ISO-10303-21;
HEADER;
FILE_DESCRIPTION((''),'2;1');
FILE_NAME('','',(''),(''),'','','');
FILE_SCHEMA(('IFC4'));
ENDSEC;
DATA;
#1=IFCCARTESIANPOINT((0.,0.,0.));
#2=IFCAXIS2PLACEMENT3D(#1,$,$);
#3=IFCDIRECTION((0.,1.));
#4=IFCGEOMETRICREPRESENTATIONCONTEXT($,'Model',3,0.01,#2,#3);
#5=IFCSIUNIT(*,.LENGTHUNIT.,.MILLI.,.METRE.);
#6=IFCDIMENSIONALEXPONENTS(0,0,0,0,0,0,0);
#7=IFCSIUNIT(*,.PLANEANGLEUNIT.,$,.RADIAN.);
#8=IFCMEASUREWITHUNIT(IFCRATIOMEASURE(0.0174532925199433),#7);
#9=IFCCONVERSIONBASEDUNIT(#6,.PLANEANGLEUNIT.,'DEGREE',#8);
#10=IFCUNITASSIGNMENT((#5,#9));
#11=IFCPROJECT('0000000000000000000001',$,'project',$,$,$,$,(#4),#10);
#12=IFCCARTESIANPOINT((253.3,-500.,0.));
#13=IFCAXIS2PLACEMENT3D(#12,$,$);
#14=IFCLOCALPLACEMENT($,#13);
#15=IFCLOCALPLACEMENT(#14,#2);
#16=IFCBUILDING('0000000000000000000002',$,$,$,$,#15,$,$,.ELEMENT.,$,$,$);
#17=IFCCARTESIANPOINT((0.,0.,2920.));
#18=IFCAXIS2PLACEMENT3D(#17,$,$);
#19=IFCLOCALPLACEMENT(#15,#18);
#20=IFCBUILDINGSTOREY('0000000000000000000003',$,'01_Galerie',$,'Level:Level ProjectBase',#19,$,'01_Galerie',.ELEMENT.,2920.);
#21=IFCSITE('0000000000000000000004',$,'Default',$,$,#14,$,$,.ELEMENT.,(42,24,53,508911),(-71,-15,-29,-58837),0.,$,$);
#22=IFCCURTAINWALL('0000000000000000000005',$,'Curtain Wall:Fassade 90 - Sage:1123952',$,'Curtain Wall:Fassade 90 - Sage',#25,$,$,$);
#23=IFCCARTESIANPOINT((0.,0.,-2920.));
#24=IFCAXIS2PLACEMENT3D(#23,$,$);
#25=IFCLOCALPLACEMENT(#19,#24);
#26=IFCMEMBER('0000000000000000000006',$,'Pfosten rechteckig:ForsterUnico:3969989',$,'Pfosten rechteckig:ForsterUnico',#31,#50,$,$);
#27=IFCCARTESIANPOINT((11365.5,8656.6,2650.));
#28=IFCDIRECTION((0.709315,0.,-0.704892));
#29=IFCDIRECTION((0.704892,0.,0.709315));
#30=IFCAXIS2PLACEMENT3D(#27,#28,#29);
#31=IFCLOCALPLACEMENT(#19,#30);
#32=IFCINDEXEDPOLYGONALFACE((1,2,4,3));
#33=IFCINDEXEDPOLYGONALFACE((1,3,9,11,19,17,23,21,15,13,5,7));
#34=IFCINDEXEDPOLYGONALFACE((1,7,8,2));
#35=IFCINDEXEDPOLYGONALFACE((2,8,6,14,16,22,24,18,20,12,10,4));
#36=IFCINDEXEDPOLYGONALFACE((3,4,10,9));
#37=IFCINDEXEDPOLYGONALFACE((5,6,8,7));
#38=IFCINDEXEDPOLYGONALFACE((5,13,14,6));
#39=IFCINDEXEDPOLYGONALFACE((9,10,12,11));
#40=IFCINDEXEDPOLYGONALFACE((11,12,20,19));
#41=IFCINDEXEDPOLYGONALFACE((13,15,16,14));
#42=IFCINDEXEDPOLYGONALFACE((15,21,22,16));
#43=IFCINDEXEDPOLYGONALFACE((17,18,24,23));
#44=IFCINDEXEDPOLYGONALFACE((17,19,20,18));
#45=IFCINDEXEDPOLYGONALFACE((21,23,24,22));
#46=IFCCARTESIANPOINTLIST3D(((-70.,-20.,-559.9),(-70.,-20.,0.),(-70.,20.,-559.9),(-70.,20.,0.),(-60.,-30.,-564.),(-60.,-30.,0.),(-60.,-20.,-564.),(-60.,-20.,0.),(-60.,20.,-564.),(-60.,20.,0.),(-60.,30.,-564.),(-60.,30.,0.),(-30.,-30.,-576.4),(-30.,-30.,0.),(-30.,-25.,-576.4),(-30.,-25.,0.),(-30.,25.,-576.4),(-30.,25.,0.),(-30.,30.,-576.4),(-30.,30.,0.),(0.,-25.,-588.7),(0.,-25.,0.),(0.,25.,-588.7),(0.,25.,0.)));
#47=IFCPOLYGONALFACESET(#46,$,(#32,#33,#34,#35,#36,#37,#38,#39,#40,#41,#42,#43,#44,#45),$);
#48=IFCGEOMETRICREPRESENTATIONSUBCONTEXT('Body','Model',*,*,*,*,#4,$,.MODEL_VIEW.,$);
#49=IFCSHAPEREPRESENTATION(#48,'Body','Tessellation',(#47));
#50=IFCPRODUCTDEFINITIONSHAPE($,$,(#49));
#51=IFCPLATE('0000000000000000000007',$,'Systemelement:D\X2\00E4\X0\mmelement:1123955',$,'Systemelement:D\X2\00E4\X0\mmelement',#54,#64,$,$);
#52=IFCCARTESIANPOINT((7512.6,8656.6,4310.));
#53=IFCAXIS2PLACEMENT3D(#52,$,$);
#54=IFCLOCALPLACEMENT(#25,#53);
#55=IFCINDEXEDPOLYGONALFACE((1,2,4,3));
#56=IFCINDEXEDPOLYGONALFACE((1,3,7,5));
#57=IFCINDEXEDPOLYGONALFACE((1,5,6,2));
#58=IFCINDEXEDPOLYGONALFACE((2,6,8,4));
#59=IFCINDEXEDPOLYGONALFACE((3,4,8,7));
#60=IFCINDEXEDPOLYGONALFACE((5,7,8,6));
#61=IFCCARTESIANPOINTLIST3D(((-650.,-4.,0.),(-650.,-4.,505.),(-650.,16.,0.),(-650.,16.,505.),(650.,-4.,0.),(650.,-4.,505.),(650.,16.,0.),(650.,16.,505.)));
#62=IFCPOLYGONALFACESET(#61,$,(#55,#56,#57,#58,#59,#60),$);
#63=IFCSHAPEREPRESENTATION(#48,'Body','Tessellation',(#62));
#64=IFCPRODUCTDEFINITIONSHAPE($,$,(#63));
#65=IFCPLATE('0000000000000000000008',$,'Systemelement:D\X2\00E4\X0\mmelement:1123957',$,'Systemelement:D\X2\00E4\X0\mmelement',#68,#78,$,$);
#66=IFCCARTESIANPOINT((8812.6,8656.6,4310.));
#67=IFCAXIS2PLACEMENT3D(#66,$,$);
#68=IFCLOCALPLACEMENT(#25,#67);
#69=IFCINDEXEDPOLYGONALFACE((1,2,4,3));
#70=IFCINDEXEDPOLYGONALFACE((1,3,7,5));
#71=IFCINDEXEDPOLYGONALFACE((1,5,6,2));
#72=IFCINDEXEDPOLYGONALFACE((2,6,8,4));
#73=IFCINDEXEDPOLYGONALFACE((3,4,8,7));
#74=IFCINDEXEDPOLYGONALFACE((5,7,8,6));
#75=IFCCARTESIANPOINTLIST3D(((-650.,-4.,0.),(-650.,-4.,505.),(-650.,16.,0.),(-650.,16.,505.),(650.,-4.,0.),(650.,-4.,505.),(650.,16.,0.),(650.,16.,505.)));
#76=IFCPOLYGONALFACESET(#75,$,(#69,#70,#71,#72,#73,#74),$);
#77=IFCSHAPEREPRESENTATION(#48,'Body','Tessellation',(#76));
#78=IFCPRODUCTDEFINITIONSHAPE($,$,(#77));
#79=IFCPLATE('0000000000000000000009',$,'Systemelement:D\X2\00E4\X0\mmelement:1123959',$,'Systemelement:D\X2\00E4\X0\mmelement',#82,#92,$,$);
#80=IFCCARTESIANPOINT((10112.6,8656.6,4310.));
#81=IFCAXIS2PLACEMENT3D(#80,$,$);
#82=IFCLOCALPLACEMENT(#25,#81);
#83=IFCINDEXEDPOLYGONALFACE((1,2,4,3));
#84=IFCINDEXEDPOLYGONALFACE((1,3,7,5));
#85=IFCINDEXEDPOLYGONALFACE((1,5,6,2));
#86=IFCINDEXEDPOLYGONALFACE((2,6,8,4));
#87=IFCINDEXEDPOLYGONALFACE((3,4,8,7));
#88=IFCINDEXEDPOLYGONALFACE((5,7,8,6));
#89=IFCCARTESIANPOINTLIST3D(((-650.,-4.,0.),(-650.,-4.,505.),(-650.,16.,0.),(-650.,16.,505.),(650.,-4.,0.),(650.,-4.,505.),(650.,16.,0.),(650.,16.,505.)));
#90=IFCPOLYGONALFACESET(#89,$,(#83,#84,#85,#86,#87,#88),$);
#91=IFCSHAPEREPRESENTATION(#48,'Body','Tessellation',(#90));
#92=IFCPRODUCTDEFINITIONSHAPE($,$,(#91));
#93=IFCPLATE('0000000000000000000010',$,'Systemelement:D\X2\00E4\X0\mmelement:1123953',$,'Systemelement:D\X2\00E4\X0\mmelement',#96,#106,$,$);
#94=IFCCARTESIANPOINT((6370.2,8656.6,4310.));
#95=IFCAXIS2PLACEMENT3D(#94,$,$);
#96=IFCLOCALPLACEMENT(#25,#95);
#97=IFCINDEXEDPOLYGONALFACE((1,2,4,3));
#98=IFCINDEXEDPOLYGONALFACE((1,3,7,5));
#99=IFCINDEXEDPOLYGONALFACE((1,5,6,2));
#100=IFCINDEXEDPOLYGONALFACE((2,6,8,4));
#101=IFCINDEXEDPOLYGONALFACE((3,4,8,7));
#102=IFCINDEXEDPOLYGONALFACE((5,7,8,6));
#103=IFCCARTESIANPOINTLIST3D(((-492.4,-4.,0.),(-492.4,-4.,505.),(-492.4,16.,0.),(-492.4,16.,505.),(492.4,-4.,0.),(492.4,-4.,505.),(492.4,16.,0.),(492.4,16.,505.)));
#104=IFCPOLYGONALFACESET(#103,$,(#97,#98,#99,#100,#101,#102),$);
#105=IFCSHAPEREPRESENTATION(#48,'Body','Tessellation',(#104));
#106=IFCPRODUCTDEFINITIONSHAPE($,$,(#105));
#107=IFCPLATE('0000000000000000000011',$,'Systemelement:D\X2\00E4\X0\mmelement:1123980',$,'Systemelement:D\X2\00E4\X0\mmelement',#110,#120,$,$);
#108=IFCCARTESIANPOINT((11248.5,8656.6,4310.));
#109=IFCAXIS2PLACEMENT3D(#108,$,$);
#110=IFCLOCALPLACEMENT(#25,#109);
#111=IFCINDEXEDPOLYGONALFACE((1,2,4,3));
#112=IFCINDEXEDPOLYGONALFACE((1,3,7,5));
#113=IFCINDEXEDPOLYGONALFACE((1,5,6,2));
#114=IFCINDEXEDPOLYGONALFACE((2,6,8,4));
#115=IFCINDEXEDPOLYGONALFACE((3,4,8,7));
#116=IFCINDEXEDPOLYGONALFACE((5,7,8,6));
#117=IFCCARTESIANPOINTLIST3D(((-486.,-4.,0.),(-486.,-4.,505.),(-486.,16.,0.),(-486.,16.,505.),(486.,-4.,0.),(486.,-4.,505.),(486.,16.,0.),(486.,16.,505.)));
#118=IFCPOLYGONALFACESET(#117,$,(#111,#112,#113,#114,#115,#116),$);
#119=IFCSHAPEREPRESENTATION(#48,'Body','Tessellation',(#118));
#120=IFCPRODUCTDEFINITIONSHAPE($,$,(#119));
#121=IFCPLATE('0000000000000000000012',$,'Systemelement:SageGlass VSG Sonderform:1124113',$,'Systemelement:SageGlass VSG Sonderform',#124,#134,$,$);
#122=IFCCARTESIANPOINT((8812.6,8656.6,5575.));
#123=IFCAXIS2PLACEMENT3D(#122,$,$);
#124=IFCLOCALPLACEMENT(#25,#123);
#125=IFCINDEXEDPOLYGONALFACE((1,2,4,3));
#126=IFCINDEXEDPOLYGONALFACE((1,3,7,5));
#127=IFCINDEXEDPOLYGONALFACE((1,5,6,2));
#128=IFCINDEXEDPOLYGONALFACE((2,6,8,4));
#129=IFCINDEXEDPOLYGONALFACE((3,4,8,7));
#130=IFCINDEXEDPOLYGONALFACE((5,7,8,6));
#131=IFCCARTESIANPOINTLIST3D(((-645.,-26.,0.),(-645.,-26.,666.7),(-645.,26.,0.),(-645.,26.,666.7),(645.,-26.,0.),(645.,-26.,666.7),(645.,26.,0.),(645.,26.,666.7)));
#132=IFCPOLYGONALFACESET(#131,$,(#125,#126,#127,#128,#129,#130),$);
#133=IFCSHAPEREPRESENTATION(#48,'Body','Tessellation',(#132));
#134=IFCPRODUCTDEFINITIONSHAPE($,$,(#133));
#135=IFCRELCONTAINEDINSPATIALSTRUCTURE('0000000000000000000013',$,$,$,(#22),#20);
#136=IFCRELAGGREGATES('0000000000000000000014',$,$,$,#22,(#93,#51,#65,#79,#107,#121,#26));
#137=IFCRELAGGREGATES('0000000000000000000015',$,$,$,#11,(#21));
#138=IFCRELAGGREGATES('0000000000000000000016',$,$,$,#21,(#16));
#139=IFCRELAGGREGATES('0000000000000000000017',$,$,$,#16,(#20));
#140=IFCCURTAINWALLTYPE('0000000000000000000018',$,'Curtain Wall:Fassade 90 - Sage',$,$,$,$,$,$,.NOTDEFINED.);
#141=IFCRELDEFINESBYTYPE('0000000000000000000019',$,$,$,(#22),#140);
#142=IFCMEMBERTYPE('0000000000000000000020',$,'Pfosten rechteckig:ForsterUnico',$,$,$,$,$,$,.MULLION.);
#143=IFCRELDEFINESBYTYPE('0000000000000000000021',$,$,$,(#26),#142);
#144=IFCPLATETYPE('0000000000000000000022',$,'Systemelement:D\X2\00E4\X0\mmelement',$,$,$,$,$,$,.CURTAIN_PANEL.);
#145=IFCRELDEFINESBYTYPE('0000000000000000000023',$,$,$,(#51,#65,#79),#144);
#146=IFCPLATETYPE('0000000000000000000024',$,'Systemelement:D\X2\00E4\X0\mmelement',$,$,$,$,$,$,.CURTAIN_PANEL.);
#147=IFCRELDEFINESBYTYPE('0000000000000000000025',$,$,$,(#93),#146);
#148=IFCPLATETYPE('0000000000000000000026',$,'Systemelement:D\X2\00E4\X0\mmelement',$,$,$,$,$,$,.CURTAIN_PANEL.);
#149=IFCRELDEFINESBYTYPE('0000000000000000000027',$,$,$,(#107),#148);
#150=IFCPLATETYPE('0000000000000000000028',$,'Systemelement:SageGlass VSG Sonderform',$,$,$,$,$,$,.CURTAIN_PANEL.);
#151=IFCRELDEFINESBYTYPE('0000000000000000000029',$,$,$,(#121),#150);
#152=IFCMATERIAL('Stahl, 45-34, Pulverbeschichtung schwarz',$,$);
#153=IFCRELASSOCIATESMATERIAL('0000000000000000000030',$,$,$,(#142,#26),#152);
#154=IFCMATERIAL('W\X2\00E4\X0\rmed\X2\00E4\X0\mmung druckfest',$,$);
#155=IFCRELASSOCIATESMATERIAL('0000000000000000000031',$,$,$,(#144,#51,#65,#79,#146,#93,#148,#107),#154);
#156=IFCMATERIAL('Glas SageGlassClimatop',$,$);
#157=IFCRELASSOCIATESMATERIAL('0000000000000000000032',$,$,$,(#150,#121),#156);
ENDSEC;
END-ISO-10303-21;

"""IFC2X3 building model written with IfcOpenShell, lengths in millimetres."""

from ifc_helpers import new_model, entity, si_unit, converted_unit, direction, frame, origin, origin_2d_with_axis, place, context, subcontext, project, spatial, polyline, rectangle, outline, extrude, clip, halfspace, source, transform, mapped, material, type_object, type_shapes, element, aggregate, save


model = new_model("IFC2X3")

# Units and contexts
model_context = context("Model", 3, precision=0.01, world=origin(), true_north=direction((0.0, 1.0)))
body_context = subcontext(model_context, "Body", "Model", "MODEL_VIEW")
ifc_project = project(units=[si_unit("LENGTHUNIT", "METRE", prefix="MILLI"), converted_unit("PLANEANGLEUNIT", "DEGREE", entity("IfcRatioMeasure", 0.0174532925199433), si_unit("PLANEANGLEUNIT", "RADIAN"), dimensions=[0, 0, 0, 0, 0, 0, 0])], contexts=[model_context])

# Site, building, storey
site_placement = place(None, frame((253.3, -500.0, 0.0)))
site = spatial("IfcSite", under=ifc_project, at=site_placement, Name="Default", CompositionType="ELEMENT", RefLatitude=(42, 24, 53, 508911), RefLongitude=(-71, -15, -29, -58837), RefElevation=0.0)
building_placement = place(site_placement, origin())
building = spatial("IfcBuilding", under=site, at=building_placement, CompositionType="ELEMENT")
storey_placement = place(building_placement, frame((0.0, 0.0, 2920.0)))
storey = spatial("IfcBuildingStorey", under=building, at=storey_placement, Name="01_Galerie", ObjectType="Level:Level ProjectBase", LongName="01_Galerie", CompositionType="ELEMENT", Elevation=2920.0)

# Curtain wall, member
curtain_wall_type = type_object("IfcCurtainWallType", Name="Curtain Wall:Fassade 90 - Sage", PredefinedType="NOTDEFINED")
curtain_wall_1_placement = place(storey_placement, frame((0.0, 0.0, -2920.0)))
curtain_wall_1 = element("IfcCurtainWall", 1, at=curtain_wall_1_placement, inside=storey, type_object=curtain_wall_type, Name="Curtain Wall:Fassade 90 - Sage:1123952", ObjectType="Curtain Wall:Fassade 90 - Sage")
ifc_material_1 = material(Name="Stahl, 45-34, Pulverbeschichtung schwarz")
member_type_1 = type_object("IfcMemberType", Name="Pfosten rechteckig:ForsterUnico", PredefinedType="MULLION", material=ifc_material_1)
shared_shape_1 = source(origin(), body_context, "Body", "Clipping", [
    clip(extrude(outline(polyline([(-20.0, -28.3), (20.0, -28.3), (20.0, -18.3), (30.0, -18.3), (30.0, 11.7), (25.0, 11.7), (25.0, 41.7), (-25.0, 41.7), (-25.0, 11.7), (-30.0, 11.7), (-30.0, -18.3), (-20.0, -18.3), (-20.0, -28.3)])), frame((-41.7, 0.0, -588.7), z_axis=(0.0, 0.0, 1.0), x_axis=(0.0, -1.0, 0.0)), (0.0, 0.0, 1.0), 588.7), halfspace(frame((0.0, -304.8, -588.7), z_axis=(-0.381238, 0.0, -0.924477), x_axis=(-0.924477, 0.0, 0.381238)), False)),
])
type_shapes(member_type_1, [shared_shape_1])
member_1_placement = place(storey_placement, frame((11365.5, 8656.6, 2650.0), z_axis=(0.709315, 0.0, -0.704892), x_axis=(0.704892, 0.0, 0.709315)))
member_1 = element("IfcMember", 2, at=member_1_placement, type_object=member_type_1, material=ifc_material_1, Name="Pfosten rechteckig:ForsterUnico:3969989", ObjectType="Pfosten rechteckig:ForsterUnico", context=body_context, shape_type="MappedRepresentation", body=[
    mapped(shared_shape_1, transform((0.0, 0.0, 0.0), scale=1.0)),
])

# Plates
ifc_material_2 = material(Name="Wärmedämmung druckfest")
plate_type_1 = type_object("IfcPlateType", Name="Systemelement:Dämmelement", PredefinedType="CURTAIN_PANEL", material=ifc_material_2)
shared_shape_2 = source(origin(), body_context, "Body", "SweptSolid", [
    extrude(rectangle(XDim=20.0, YDim=1300.0, at=origin_2d_with_axis()), frame((0.0, 6.0, 0.0), z_axis=(0.0, 0.0, 1.0), x_axis=(0.0, 1.0, 0.0)), (0.0, 0.0, 1.0), 505.0),
])
type_shapes(plate_type_1, [shared_shape_2])
plate_1_placement = place(curtain_wall_1_placement, frame((7512.6, 8656.6, 4310.0)))
plate_1 = element("IfcPlate", 3, at=plate_1_placement, type_object=plate_type_1, material=ifc_material_2, Name="Systemelement:Dämmelement:1123955", ObjectType="Systemelement:Dämmelement", context=body_context, shape_type="MappedRepresentation", body=[
    mapped(shared_shape_2, transform((0.0, 0.0, 0.0), scale=1.0)),
])
plate_2_placement = place(curtain_wall_1_placement, frame((8812.6, 8656.6, 4310.0)))
plate_2 = element("IfcPlate", 4, at=plate_2_placement, type_object=plate_type_1, material=ifc_material_2, Name="Systemelement:Dämmelement:1123957", ObjectType="Systemelement:Dämmelement", context=body_context, shape_type="MappedRepresentation", body=[
    mapped(shared_shape_2, transform((0.0, 0.0, 0.0), scale=1.0)),
])
plate_3_placement = place(curtain_wall_1_placement, frame((10112.6, 8656.6, 4310.0)))
plate_3 = element("IfcPlate", 5, at=plate_3_placement, type_object=plate_type_1, material=ifc_material_2, Name="Systemelement:Dämmelement:1123959", ObjectType="Systemelement:Dämmelement", context=body_context, shape_type="MappedRepresentation", body=[
    mapped(shared_shape_2, transform((0.0, 0.0, 0.0), scale=1.0)),
])
plate_type_2 = type_object("IfcPlateType", Name="Systemelement:Dämmelement", PredefinedType="CURTAIN_PANEL", material=ifc_material_2)
shared_shape_3 = source(origin(), body_context, "Body", "SweptSolid", [
    extrude(rectangle(XDim=20.0, YDim=984.7, at=origin_2d_with_axis()), frame((0.0, 6.0, 0.0), z_axis=(0.0, 0.0, 1.0), x_axis=(0.0, 1.0, 0.0)), (0.0, 0.0, 1.0), 505.0),
])
type_shapes(plate_type_2, [shared_shape_3])
plate_4_placement = place(curtain_wall_1_placement, frame((6370.2, 8656.6, 4310.0)))
plate_4 = element("IfcPlate", 6, at=plate_4_placement, type_object=plate_type_2, material=ifc_material_2, Name="Systemelement:Dämmelement:1123953", ObjectType="Systemelement:Dämmelement", context=body_context, shape_type="MappedRepresentation", body=[
    mapped(shared_shape_3, transform((0.0, 0.0, 0.0), scale=1.0)),
])
plate_type_3 = type_object("IfcPlateType", Name="Systemelement:Dämmelement", PredefinedType="CURTAIN_PANEL", material=ifc_material_2)
shared_shape_4 = source(origin(), body_context, "Body", "SweptSolid", [
    extrude(rectangle(XDim=20.0, YDim=972.0, at=origin_2d_with_axis()), frame((0.0, 6.0, 0.0), z_axis=(0.0, 0.0, 1.0), x_axis=(0.0, 1.0, 0.0)), (0.0, 0.0, 1.0), 505.0),
])
type_shapes(plate_type_3, [shared_shape_4])
plate_5_placement = place(curtain_wall_1_placement, frame((11248.5, 8656.6, 4310.0)))
plate_5 = element("IfcPlate", 7, at=plate_5_placement, type_object=plate_type_3, material=ifc_material_2, Name="Systemelement:Dämmelement:1123980", ObjectType="Systemelement:Dämmelement", context=body_context, shape_type="MappedRepresentation", body=[
    mapped(shared_shape_4, transform((0.0, 0.0, 0.0), scale=1.0)),
])
ifc_material_3 = material(Name="Glas SageGlassClimatop")
plate_type_4 = type_object("IfcPlateType", Name="Systemelement:SageGlass VSG Sonderform", PredefinedType="CURTAIN_PANEL", material=ifc_material_3)
shared_shape_5 = source(origin(), body_context, "Body", "SweptSolid", [
    extrude(rectangle(XDim=52.0, YDim=1290.0, at=origin_2d_with_axis()), frame((0.0, 0.0, 0.0), z_axis=(0.0, 0.0, 1.0), x_axis=(0.0, 1.0, 0.0)), (0.0, 0.0, 1.0), 666.7),
])
type_shapes(plate_type_4, [shared_shape_5])
plate_6_placement = place(curtain_wall_1_placement, frame((8812.6, 8656.6, 5575.0)))
plate_6 = element("IfcPlate", 8, at=plate_6_placement, type_object=plate_type_4, material=ifc_material_3, Name="Systemelement:SageGlass VSG Sonderform:1124113", ObjectType="Systemelement:SageGlass VSG Sonderform", context=body_context, shape_type="MappedRepresentation", body=[
    mapped(shared_shape_5, transform((0.0, 0.0, 0.0), scale=1.0)),
])

aggregate(curtain_wall_1, [plate_4, plate_1, plate_2, plate_3, plate_5, plate_6, member_1])

save(model, "model.ifc")
